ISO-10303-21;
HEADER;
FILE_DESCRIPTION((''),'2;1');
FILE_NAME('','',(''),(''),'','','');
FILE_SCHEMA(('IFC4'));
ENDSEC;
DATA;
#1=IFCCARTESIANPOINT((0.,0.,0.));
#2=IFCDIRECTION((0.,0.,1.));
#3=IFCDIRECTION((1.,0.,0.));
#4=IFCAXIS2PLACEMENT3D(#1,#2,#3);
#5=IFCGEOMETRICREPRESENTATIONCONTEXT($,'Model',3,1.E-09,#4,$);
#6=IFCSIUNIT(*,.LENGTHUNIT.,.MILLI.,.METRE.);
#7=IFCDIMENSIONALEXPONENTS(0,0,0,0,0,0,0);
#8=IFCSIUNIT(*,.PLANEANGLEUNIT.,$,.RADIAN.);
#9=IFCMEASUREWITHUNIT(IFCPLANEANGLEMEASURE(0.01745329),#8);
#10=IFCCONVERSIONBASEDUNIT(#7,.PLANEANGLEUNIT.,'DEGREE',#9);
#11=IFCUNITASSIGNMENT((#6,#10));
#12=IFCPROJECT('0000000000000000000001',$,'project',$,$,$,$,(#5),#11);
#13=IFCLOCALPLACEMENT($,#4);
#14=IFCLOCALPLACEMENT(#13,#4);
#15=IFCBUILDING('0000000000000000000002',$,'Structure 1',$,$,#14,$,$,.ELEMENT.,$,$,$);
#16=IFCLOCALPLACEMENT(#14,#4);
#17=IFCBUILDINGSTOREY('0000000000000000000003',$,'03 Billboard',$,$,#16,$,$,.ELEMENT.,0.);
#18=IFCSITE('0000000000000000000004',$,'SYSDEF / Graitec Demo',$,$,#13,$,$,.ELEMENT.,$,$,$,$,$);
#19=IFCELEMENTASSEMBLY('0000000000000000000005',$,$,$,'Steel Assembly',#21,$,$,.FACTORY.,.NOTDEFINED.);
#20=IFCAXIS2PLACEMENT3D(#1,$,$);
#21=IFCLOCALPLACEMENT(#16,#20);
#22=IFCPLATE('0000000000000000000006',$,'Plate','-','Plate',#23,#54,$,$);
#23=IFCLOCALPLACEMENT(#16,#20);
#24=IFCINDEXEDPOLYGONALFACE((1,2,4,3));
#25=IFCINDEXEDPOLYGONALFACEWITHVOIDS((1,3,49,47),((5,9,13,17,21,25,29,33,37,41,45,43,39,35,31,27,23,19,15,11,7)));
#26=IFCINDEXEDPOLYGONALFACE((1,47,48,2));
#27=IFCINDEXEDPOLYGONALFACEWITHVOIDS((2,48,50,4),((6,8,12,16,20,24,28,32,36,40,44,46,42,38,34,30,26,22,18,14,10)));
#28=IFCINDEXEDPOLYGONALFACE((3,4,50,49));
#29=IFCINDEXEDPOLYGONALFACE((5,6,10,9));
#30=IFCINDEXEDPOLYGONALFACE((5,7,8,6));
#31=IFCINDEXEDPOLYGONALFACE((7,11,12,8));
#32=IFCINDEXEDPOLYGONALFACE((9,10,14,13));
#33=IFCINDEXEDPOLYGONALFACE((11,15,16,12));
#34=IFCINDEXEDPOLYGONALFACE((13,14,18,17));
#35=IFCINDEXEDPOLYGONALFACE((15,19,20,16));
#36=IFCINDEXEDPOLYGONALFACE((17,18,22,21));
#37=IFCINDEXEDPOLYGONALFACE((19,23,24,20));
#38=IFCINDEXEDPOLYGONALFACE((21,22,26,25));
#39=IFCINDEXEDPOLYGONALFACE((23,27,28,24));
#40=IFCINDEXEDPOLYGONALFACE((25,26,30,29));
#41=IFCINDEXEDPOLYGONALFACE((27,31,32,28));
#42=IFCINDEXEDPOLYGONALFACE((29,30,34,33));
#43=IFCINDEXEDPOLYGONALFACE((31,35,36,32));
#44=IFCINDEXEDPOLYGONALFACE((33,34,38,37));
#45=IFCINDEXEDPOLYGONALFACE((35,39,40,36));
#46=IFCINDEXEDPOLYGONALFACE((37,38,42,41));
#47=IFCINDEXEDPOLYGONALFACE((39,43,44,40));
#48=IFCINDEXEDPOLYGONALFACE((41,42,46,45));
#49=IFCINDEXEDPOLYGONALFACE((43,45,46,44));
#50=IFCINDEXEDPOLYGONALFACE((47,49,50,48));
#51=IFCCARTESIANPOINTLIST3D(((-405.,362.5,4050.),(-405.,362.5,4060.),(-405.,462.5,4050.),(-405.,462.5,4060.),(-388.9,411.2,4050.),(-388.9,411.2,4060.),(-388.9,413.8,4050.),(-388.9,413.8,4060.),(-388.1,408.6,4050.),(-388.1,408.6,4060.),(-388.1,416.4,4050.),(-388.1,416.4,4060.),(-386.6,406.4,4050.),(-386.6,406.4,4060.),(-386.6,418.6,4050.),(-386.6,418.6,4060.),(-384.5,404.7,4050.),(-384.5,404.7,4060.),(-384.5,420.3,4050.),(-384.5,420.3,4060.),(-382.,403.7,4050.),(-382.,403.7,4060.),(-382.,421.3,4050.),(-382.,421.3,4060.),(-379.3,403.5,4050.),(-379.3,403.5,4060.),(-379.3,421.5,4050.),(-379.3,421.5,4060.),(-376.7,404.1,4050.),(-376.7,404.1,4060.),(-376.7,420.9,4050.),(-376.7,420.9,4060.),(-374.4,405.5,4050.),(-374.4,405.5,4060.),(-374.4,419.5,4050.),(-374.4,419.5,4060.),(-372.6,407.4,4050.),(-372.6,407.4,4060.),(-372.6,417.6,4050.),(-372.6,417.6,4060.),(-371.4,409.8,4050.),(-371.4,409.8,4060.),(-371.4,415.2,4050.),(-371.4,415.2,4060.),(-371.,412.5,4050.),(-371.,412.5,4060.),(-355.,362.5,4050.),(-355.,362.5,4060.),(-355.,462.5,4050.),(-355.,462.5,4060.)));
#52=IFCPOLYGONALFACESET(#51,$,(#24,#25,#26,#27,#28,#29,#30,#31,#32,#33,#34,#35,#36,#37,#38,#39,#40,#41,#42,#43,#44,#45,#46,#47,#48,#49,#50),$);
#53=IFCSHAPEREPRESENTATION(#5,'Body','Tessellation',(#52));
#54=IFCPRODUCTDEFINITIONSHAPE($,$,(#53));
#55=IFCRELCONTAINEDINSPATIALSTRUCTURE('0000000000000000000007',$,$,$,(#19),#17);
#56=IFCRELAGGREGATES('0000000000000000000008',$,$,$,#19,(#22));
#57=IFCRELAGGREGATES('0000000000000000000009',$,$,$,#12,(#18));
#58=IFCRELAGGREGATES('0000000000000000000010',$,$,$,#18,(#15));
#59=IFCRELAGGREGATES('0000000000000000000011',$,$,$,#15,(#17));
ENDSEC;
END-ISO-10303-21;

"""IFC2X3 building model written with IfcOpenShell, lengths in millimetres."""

from ifc_helpers import new_model, entity, si_unit, converted_unit, frame, frame_2d, origin, origin_with_axes, place, context, project, spatial, polyline, circle, outline, extrude, element, aggregate, save


model = new_model("IFC2X3")

# Units and contexts
model_context = context("Model", 3, precision=1e-09, world=origin_with_axes())
ifc_project = project(units=[si_unit("LENGTHUNIT", "METRE", prefix="MILLI"), converted_unit("PLANEANGLEUNIT", "DEGREE", entity("IfcPlaneAngleMeasure", 0.01745329), si_unit("PLANEANGLEUNIT", "RADIAN"), dimensions=[0, 0, 0, 0, 0, 0, 0])], contexts=[model_context])

# Site, building, storey
site_placement = place(None, origin_with_axes())
site = spatial("IfcSite", under=ifc_project, at=site_placement, Name="SYSDEF / Graitec Demo", CompositionType="ELEMENT")
building_placement = place(site_placement, origin_with_axes())
building = spatial("IfcBuilding", under=site, at=building_placement, Name="Structure 1", CompositionType="ELEMENT")
storey_placement = place(building_placement, origin_with_axes())
storey = spatial("IfcBuildingStorey", under=building, at=storey_placement, Name="03 Billboard", CompositionType="ELEMENT", Elevation=0.0)

# Element assembly, plate, opening
assembly_1_placement = place(None, frame((-380.0, 412.5, 4060.0), z_axis=(0.0, 0.0, -1.0), x_axis=(1.0, 0.0, 0.0)))
assembly_1 = element("IfcElementAssembly", 1, at=assembly_1_placement, inside=storey, ObjectType="Steel Assembly", AssemblyPlace="FACTORY", PredefinedType="NOTDEFINED")
plate_placement = place(assembly_1_placement, origin_with_axes())
plate = element("IfcPlate", 2, at=plate_placement, Name="Plate", Description="-", ObjectType="Plate", context=model_context, shape_type="SweptSolid", body=[
    extrude(outline(polyline([(-25.0, -50.0), (25.0, -50.0), (25.0, 50.0), (-25.0, 50.0), (-25.0, -50.0)])), origin_with_axes(), (0.0, 0.0, 1.0), 10.0),
])
opening_1_placement = place(plate_placement, frame((-9.0, 0.0, 10.5), z_axis=(0.0, 0.0, 1.0), x_axis=(1.0, 0.0, 0.0)))
element("IfcOpeningElement", 3, at=opening_1_placement, cuts=plate, ObjectType="Opening", context=model_context, shape_type="SweptSolid", body=[
    extrude(circle(Radius=9.0, at=frame_2d((9.0, 0.0), x_axis=(1.0, 0.0))), origin(), (0.0, 0.0, -1.0), 11.0),
])
aggregate(assembly_1, [plate])

save(model, "model.ifc")
